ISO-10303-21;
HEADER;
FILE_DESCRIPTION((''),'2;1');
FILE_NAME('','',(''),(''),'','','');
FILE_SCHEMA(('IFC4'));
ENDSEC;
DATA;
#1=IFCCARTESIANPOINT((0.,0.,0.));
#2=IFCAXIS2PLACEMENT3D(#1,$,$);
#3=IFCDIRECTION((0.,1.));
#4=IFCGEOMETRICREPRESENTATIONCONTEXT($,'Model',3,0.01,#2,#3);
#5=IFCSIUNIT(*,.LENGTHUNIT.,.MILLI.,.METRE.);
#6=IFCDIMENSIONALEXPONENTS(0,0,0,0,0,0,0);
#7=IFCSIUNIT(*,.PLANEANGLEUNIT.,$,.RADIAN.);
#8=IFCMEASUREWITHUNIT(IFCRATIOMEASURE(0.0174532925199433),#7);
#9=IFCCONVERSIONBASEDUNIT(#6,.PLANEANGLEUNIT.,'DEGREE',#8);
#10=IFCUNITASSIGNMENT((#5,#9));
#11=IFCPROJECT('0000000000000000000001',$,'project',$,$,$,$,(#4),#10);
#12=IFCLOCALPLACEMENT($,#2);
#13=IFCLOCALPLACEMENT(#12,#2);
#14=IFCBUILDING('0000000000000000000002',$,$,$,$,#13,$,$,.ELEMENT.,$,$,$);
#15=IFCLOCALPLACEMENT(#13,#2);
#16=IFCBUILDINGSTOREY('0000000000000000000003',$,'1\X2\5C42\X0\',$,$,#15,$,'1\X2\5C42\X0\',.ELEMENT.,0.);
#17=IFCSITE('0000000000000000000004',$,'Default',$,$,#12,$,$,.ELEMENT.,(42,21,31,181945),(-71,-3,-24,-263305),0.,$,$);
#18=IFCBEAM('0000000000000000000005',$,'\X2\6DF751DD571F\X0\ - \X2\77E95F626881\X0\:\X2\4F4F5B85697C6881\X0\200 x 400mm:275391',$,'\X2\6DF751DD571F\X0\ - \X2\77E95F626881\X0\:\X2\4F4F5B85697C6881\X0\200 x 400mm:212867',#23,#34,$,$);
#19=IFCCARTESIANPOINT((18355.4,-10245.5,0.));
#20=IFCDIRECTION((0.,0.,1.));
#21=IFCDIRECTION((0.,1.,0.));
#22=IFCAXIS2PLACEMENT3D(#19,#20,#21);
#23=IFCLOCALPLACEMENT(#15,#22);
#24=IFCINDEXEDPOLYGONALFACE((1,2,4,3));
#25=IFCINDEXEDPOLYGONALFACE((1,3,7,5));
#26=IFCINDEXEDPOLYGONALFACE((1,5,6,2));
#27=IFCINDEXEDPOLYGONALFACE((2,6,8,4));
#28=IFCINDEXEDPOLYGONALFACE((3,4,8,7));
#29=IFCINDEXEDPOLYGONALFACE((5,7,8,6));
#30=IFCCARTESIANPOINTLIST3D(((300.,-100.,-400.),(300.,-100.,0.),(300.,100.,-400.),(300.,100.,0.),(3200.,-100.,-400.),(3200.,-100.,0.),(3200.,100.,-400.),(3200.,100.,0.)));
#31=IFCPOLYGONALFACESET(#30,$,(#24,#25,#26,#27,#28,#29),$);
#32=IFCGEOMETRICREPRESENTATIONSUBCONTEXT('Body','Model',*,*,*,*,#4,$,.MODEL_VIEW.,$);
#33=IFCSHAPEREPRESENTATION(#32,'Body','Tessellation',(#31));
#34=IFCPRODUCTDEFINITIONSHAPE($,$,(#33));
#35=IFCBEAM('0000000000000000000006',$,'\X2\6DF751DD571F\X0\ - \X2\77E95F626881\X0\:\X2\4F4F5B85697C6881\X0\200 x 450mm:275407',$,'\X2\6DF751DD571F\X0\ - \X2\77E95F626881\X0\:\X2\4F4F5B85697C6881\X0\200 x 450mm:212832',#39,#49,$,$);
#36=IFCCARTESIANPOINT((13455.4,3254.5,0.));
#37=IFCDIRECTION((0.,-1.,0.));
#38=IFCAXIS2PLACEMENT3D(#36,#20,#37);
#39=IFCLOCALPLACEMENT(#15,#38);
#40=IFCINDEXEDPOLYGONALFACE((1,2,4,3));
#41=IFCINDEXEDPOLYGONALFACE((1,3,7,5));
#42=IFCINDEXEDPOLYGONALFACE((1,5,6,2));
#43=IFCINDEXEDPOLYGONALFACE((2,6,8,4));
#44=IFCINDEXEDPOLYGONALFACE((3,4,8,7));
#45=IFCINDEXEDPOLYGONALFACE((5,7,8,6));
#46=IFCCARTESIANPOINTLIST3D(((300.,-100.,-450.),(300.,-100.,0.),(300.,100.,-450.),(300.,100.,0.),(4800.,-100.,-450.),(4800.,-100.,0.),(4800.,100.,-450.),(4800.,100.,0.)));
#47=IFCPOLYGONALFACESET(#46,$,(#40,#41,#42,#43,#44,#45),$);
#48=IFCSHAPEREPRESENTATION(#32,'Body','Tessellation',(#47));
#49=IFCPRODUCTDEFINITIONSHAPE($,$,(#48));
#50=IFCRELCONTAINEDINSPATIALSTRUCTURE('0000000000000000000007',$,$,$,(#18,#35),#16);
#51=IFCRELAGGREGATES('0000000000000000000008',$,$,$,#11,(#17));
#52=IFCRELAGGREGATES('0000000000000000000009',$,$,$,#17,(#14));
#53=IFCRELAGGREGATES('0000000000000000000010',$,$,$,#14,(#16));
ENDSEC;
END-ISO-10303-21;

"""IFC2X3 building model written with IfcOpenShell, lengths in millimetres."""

from ifc_helpers import new_model, entity, si_unit, converted_unit, direction, frame, frame_2d, origin, place, context, subcontext, project, spatial, rectangle, extrude, element, save


model = new_model("IFC2X3")

# Units and contexts
model_context = context("Model", 3, precision=0.01, world=origin(), true_north=direction((0.0, 1.0)))
body_context = subcontext(model_context, "Body", "Model", "MODEL_VIEW")
ifc_project = project(units=[si_unit("LENGTHUNIT", "METRE", prefix="MILLI"), converted_unit("PLANEANGLEUNIT", "DEGREE", entity("IfcRatioMeasure", 0.0174532925199433), si_unit("PLANEANGLEUNIT", "RADIAN"), dimensions=[0, 0, 0, 0, 0, 0, 0])], contexts=[model_context])

# Site, building, storey
site_placement = place(None, origin())
site = spatial("IfcSite", under=ifc_project, at=site_placement, Name="Default", CompositionType="ELEMENT", RefLatitude=(42, 21, 31, 181945), RefLongitude=(-71, -3, -24, -263305), RefElevation=0.0)
building_placement = place(site_placement, origin())
building = spatial("IfcBuilding", under=site, at=building_placement, CompositionType="ELEMENT")
storey_placement = place(building_placement, origin())
storey = spatial("IfcBuildingStorey", under=building, at=storey_placement, Name="1层", LongName="1层", CompositionType="ELEMENT", Elevation=0.0)

# Beams
beam_1_placement = place(storey_placement, frame((18355.4, -10245.5, 0.0), z_axis=(0.0, 0.0, 1.0), x_axis=(0.0, 1.0, 0.0)))
element("IfcBeam", 1, at=beam_1_placement, inside=storey, Name="混凝土 - 矩形梁:住宅楼梁200 x 400mm:275391", ObjectType="混凝土 - 矩形梁:住宅楼梁200 x 400mm:212867", context=body_context, shape_type="SweptSolid", body=[
    extrude(rectangle(XDim=400.0, YDim=200.0, at=frame_2d((0.0, 0.0), x_axis=(1.0, 0.0))), frame((300.0, 0.0, -200.0), z_axis=(1.0, 0.0, 0.0), x_axis=(0.0, 0.0, -1.0)), (0.0, 0.0, 1.0), 2900.0),
])
beam_2_placement = place(storey_placement, frame((13455.4, 3254.5, 0.0), z_axis=(0.0, 0.0, 1.0), x_axis=(0.0, -1.0, 0.0)))
element("IfcBeam", 2, at=beam_2_placement, inside=storey, Name="混凝土 - 矩形梁:住宅楼梁200 x 450mm:275407", ObjectType="混凝土 - 矩形梁:住宅楼梁200 x 450mm:212832", context=body_context, shape_type="SweptSolid", body=[
    extrude(rectangle(XDim=450.0, YDim=200.0, at=frame_2d((0.0, 0.0), x_axis=(1.0, 0.0))), frame((300.0, 0.0, -225.0), z_axis=(1.0, 0.0, 0.0), x_axis=(0.0, 0.0, -1.0)), (0.0, 0.0, 1.0), 4500.0),
])

save(model, "model.ifc")
